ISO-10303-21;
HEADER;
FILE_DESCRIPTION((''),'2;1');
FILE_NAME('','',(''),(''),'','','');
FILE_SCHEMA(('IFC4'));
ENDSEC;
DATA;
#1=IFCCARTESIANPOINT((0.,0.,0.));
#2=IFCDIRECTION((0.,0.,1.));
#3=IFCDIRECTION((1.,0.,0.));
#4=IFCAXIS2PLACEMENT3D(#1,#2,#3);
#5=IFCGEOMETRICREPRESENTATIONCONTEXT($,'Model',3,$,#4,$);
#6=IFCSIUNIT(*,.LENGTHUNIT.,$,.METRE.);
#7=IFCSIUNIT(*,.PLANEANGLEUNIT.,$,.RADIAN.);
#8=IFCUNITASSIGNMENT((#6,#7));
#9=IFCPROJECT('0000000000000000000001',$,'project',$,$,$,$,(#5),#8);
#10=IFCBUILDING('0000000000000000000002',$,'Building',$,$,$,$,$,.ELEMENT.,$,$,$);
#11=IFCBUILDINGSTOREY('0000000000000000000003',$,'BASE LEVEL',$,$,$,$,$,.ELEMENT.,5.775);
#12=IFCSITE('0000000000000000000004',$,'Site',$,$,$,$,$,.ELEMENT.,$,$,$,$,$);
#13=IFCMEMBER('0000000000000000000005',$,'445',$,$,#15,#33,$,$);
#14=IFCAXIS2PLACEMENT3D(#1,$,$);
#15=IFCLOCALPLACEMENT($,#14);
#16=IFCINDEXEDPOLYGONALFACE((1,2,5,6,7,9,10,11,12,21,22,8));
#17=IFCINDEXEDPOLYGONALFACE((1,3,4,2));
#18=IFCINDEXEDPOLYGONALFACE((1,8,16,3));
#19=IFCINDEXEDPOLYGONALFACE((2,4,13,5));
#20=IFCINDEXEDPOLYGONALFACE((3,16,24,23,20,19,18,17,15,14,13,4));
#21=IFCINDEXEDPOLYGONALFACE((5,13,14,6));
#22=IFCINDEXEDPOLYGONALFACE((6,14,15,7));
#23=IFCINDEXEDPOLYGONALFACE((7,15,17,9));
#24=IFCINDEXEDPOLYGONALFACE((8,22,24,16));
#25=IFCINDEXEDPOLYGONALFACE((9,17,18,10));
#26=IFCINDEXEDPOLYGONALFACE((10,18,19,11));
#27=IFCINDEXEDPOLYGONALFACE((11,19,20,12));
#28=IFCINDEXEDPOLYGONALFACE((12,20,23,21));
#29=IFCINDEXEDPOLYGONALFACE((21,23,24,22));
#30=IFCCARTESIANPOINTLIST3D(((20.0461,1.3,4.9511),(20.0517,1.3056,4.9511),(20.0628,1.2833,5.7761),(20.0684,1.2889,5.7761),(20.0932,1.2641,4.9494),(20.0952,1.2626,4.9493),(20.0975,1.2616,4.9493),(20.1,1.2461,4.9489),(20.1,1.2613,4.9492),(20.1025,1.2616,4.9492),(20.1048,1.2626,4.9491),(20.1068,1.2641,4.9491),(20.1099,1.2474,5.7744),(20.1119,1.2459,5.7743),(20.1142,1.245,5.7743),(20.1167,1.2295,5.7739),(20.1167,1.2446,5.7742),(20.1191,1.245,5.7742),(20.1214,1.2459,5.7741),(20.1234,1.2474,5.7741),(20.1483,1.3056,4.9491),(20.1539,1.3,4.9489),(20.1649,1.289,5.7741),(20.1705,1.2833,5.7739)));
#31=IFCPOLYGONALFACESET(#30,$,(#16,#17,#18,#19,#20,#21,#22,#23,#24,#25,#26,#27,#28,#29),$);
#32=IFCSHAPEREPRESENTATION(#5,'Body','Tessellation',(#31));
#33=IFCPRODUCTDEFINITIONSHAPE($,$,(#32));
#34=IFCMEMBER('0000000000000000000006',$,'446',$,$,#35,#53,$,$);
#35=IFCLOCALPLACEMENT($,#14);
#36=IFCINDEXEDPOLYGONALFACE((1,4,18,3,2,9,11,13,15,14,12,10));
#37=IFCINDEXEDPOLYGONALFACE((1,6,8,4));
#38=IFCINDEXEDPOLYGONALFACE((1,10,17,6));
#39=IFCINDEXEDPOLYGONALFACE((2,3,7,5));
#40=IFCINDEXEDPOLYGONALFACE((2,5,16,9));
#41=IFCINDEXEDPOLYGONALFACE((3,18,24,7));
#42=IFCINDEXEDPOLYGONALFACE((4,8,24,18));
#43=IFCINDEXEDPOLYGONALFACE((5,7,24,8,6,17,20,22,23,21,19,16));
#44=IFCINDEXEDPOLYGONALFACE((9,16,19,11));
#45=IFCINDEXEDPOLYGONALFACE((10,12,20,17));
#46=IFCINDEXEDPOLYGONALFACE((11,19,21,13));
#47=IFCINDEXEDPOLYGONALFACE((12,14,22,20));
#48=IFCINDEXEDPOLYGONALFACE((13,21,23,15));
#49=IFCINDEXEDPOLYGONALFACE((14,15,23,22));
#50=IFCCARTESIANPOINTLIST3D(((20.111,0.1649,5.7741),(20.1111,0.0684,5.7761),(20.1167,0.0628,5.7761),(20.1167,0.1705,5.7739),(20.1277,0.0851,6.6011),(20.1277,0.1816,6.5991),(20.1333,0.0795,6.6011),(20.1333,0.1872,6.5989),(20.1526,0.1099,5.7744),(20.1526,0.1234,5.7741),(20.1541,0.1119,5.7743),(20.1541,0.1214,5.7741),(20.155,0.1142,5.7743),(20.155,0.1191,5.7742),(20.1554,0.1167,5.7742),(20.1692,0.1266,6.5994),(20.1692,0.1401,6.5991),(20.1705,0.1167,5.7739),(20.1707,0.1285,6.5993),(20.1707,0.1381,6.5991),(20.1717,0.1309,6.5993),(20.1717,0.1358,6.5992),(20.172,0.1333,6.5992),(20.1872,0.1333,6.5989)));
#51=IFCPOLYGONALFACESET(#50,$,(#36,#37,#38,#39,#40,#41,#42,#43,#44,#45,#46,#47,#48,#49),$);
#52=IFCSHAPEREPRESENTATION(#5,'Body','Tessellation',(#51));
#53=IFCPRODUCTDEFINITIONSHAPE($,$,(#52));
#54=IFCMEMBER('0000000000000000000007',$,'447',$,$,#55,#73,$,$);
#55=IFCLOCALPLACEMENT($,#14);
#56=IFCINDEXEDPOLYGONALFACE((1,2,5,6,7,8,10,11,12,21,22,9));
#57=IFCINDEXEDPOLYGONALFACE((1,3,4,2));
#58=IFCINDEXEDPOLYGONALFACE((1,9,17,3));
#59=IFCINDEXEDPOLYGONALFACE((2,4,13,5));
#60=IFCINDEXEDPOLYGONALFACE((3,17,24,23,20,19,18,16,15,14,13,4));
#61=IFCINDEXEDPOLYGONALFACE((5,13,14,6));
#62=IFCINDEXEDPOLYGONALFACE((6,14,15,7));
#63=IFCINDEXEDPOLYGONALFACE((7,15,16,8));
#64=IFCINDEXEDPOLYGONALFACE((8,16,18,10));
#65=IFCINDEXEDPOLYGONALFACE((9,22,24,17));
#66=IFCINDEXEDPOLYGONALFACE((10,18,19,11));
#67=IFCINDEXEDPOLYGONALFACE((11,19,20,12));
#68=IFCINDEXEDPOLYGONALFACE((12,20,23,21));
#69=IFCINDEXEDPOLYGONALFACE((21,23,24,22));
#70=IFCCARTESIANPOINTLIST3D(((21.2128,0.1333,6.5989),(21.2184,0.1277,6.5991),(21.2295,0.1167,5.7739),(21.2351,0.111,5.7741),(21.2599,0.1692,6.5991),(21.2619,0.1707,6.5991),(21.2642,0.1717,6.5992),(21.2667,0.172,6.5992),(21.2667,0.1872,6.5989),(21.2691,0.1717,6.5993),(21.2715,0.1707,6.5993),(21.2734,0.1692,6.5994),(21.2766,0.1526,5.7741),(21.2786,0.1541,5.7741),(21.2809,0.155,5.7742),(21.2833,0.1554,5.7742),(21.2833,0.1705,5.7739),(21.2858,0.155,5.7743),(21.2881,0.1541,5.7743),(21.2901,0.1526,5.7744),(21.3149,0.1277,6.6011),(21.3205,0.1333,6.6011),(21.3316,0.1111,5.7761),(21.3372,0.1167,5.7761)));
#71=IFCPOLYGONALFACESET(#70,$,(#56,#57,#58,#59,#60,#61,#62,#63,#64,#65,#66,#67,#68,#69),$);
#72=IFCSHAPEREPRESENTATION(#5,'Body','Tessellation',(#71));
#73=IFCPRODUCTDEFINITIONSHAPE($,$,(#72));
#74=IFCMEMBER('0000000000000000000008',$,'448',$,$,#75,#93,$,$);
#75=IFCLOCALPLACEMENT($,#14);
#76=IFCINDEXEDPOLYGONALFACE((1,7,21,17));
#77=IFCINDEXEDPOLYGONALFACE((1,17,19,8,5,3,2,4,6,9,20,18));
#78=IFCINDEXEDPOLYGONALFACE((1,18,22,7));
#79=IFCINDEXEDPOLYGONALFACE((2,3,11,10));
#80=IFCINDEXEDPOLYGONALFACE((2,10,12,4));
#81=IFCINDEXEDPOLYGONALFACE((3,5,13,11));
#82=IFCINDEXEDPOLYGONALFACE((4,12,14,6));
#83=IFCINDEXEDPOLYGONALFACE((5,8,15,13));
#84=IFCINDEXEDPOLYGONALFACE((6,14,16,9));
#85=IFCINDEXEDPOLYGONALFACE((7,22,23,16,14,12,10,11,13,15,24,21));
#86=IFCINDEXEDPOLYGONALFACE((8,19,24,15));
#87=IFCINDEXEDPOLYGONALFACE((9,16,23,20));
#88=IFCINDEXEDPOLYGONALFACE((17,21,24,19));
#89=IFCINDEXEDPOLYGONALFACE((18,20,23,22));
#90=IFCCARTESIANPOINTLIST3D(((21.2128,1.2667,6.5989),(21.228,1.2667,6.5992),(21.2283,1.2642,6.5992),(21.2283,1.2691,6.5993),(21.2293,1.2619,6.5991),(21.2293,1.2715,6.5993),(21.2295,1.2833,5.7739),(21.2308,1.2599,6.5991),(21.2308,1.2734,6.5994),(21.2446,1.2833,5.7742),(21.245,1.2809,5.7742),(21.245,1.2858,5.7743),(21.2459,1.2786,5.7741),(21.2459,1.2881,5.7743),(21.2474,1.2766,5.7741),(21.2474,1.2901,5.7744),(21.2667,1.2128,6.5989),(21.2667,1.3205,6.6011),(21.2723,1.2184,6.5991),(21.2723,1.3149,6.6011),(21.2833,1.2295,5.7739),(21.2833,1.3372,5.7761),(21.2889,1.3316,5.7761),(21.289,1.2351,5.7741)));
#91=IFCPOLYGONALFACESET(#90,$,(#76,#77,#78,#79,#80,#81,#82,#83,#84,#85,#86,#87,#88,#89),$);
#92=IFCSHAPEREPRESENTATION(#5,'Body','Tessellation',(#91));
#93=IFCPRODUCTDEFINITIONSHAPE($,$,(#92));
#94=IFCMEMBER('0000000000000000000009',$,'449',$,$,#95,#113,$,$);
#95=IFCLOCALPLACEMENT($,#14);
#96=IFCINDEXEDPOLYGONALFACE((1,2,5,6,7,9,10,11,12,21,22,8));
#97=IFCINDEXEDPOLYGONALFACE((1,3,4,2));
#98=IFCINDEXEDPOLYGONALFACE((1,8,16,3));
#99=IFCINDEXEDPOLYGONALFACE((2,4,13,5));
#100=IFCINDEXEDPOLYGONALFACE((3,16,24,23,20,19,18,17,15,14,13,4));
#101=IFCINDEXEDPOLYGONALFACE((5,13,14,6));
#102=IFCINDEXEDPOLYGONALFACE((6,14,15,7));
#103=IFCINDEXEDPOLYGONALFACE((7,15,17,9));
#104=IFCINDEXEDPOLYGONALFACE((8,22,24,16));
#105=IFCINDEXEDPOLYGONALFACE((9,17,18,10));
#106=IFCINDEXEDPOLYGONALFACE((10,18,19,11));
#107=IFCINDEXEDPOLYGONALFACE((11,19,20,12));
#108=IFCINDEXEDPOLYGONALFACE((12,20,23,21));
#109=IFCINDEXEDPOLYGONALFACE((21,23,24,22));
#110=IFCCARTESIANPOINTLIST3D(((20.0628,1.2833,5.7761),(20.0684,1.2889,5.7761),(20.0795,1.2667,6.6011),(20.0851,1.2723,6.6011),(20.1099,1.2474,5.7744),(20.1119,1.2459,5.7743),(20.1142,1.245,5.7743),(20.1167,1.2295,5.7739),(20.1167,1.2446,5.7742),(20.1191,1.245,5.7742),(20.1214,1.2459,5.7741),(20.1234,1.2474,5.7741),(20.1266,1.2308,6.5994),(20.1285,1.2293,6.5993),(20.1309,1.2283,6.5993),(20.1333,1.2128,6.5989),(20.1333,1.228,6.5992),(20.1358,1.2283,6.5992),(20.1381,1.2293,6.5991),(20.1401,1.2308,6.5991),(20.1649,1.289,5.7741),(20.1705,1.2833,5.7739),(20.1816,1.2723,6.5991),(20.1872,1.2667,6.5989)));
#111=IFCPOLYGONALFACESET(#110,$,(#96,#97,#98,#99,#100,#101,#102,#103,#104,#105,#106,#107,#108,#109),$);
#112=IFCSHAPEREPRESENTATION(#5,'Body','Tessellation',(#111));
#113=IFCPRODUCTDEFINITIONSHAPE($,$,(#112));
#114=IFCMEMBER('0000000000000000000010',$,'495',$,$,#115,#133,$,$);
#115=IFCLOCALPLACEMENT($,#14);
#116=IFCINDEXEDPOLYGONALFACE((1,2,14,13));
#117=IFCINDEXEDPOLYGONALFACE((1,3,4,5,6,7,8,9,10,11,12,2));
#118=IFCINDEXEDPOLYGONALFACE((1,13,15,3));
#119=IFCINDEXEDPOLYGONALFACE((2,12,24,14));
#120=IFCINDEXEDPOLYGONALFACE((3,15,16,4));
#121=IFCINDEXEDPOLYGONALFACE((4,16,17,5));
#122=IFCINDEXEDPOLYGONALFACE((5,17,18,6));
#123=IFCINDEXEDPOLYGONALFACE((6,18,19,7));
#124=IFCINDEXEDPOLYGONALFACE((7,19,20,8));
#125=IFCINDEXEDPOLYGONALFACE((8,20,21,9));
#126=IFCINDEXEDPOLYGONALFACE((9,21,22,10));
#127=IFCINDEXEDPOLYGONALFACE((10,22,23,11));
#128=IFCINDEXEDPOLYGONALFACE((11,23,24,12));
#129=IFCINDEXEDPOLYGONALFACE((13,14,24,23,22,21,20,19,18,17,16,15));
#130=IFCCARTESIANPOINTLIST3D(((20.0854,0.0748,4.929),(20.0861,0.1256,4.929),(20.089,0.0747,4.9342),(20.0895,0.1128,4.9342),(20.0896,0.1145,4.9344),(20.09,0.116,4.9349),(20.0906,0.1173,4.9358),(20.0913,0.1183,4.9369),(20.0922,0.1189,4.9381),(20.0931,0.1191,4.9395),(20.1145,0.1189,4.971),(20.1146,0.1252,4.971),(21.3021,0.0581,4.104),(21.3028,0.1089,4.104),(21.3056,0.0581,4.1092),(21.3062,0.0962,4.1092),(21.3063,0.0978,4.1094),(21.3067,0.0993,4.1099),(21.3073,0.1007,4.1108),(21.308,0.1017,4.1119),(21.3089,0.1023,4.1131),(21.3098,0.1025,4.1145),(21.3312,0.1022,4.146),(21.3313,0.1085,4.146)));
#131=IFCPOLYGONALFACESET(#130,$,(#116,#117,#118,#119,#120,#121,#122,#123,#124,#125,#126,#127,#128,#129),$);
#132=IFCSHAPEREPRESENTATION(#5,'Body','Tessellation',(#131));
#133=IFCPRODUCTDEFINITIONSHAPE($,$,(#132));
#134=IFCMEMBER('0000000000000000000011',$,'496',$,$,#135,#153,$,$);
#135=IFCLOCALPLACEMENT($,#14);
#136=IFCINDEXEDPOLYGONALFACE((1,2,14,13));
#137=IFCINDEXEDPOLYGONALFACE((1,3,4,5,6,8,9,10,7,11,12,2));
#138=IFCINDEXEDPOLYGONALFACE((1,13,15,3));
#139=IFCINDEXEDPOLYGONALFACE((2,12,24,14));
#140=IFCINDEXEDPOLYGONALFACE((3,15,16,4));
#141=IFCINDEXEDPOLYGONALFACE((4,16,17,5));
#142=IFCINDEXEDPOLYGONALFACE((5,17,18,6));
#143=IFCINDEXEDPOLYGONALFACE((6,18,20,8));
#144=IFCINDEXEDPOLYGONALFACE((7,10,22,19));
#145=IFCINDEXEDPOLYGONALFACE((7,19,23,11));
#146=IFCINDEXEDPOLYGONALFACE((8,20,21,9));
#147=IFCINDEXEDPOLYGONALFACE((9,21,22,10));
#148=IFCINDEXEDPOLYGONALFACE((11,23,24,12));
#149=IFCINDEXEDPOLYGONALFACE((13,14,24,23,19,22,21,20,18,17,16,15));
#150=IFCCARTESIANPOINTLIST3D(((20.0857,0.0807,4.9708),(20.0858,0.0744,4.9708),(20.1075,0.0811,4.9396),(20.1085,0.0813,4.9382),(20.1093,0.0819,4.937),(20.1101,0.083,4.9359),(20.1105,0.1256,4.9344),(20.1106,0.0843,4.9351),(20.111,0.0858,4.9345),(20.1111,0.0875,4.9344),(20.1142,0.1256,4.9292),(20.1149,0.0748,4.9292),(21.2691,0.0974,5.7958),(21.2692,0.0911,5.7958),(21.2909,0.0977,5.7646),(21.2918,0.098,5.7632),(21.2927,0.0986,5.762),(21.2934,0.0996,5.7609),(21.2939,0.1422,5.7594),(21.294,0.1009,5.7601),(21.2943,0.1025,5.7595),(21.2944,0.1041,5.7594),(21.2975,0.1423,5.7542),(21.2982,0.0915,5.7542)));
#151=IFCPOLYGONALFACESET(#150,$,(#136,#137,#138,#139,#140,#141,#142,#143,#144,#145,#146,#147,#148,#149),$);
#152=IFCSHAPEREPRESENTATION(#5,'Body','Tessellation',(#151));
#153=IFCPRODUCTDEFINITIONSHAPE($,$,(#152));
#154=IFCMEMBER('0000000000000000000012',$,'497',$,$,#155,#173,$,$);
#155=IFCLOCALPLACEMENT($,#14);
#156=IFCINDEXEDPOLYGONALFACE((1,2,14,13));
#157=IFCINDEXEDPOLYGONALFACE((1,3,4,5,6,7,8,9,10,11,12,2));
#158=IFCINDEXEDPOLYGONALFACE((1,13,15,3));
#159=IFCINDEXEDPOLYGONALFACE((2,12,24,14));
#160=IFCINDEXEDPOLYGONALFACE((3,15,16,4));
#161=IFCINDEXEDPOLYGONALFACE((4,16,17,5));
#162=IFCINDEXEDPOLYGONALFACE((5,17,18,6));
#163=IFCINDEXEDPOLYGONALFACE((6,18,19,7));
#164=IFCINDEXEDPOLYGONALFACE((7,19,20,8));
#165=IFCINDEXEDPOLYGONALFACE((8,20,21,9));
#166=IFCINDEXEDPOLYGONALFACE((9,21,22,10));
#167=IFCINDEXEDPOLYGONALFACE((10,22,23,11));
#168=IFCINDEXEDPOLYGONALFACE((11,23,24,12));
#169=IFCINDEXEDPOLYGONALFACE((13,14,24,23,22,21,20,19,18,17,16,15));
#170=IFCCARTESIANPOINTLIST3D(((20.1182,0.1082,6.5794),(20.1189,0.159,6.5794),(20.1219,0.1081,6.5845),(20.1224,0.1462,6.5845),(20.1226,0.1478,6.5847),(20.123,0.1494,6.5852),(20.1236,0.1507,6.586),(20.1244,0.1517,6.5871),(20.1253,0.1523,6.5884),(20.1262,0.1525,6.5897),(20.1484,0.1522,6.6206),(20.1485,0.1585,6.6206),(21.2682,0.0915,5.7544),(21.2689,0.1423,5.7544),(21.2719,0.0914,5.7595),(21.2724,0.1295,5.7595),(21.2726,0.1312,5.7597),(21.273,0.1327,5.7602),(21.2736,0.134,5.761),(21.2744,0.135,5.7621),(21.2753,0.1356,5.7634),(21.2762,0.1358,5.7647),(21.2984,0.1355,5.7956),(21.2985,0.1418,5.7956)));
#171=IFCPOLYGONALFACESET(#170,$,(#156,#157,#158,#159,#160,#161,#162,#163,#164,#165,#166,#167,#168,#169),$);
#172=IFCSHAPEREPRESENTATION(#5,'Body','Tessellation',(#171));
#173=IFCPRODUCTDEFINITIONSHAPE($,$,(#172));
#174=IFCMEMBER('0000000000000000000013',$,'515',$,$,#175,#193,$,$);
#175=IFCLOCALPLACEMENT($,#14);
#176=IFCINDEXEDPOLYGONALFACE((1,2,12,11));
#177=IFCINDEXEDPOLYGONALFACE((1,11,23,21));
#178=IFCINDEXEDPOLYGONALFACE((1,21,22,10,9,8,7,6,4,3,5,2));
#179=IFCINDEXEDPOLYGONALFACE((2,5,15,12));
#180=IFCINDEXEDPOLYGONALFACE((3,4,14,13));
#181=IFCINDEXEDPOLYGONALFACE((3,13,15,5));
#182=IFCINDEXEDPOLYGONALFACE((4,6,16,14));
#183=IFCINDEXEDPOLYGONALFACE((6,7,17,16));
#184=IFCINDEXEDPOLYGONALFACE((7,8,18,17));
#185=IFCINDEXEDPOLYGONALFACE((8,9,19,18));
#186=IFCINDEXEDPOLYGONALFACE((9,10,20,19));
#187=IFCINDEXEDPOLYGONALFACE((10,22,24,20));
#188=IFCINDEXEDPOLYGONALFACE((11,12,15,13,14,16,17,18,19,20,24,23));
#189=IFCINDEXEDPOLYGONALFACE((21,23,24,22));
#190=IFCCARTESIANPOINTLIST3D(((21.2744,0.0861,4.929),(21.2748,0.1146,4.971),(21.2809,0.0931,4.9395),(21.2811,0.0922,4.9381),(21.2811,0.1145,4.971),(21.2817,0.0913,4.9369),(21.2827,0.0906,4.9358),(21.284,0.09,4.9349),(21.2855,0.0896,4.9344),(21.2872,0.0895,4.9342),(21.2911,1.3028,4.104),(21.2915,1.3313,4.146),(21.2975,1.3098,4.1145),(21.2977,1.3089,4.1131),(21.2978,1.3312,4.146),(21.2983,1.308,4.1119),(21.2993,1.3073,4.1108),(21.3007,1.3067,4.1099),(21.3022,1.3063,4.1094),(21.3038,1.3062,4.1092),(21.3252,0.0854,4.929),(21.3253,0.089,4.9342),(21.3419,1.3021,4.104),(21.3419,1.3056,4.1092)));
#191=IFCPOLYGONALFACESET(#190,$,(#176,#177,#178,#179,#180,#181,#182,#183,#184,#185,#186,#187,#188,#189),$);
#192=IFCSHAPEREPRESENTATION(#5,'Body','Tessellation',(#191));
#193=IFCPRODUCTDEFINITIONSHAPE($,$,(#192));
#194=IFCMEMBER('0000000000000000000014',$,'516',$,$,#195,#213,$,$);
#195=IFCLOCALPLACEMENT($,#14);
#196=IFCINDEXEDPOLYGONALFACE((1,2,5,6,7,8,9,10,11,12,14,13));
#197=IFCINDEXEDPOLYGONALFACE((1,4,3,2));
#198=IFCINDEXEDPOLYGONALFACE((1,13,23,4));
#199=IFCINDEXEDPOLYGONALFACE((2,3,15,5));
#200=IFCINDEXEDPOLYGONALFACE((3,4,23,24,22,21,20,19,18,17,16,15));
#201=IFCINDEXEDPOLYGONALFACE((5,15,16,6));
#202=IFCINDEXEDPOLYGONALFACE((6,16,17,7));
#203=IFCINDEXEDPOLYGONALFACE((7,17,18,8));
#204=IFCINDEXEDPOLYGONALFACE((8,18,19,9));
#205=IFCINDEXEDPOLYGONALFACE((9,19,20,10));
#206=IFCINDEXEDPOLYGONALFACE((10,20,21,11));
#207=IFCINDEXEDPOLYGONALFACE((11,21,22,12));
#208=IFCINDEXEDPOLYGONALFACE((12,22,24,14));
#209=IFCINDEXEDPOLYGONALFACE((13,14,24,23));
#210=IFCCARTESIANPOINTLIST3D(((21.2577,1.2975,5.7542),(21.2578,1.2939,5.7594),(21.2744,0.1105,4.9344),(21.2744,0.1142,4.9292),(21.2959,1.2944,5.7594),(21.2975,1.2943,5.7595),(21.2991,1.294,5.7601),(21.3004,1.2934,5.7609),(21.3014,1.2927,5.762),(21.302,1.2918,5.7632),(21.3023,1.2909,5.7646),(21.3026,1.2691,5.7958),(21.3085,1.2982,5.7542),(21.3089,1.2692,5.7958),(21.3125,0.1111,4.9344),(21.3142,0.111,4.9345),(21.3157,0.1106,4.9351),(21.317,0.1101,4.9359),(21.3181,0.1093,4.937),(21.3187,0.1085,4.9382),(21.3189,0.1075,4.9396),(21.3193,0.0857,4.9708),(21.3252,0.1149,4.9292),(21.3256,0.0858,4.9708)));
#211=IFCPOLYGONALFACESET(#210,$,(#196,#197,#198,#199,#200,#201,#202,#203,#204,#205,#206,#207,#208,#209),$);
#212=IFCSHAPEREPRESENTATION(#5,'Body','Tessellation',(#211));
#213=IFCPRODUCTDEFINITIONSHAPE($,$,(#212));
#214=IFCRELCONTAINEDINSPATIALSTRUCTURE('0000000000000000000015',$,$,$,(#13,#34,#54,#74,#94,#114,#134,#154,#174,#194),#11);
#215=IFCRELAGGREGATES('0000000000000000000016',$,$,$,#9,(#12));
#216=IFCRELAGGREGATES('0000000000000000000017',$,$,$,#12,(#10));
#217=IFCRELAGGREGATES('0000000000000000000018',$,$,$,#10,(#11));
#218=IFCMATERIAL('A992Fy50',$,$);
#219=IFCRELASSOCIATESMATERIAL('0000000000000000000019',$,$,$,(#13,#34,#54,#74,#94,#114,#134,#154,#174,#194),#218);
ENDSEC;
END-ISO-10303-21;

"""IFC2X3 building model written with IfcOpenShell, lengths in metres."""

from ifc_helpers import new_model, si_unit, frame, origin_with_axes, origin_2d_with_axis, place, context, project, spatial, l_section, extrude, material, element, save


model = new_model("IFC2X3")

# Units and contexts
model_context = context("Model", 3, world=origin_with_axes())
ifc_project = project(units=[si_unit("LENGTHUNIT", "METRE"), si_unit("PLANEANGLEUNIT", "RADIAN")], contexts=[model_context])

# Site, building, storey
site = spatial("IfcSite", under=ifc_project, Name="Site", CompositionType="ELEMENT")
building = spatial("IfcBuilding", under=site, Name="Building", CompositionType="ELEMENT")
storey = spatial("IfcBuildingStorey", under=building, Name="BASE LEVEL", CompositionType="ELEMENT", Elevation=5.775)

# Shared definitions
ifc_material = material(Name="A992Fy50")

# Members
for number, where, z_axis, x_axis, name in (
    (1, (20.1, 1.3, 4.95), (0.020194, -0.020194, 0.999592), (0.707107, 0.707107, 0.0), "445"),
    (2, (20.1167, 0.1167, 5.775), (0.020194, 0.020194, 0.999592), (-0.707107, 0.707107, 0.0), "446"),
    (3, (21.2833, 0.1167, 5.775), (-0.020194, 0.020194, 0.999592), (-0.707107, -0.707107, 0.0), "447"),
    (4, (21.2833, 1.2833, 5.775), (-0.020194, -0.020194, 0.999592), (0.707107, -0.707107, 0.0), "448"),
    (5, (20.1167, 1.2833, 5.775), (0.020194, -0.020194, 0.999592), (0.707107, 0.707107, 0.0), "449"),
):
    element("IfcMember", number, at=place(None, frame(where, z_axis=z_axis, x_axis=x_axis)), inside=storey, material=ifc_material, Name=name, context=model_context, shape_type="SweptSolid", body=[
        extrude(l_section(Depth=0.0762, Width=0.0762, Thickness=0.0079, FilletRadius=0.0096, at=origin_2d_with_axis()), origin_with_axes(), (0.0, 0.0, 1.0), 0.8253),
    ])
member_1_placement = place(None, frame((21.3167, 0.0833, 4.125), z_axis=(-0.827611, 0.011337, 0.561188), x_axis=(-0.013697, -0.999906, 0.0)))
element("IfcMember", 6, at=member_1_placement, inside=storey, material=ifc_material, Name="495", context=model_context, shape_type="SweptSolid", body=[
    extrude(l_section(Depth=0.0508, Width=0.0508, Thickness=0.0063, FilletRadius=0.0063, at=origin_2d_with_axis()), origin_with_axes(), (0.0, 0.0, 1.0), 1.4701),
])
member_2_placement = place(None, frame((20.1, 0.1, 4.95), z_axis=(0.820261, 0.011553, 0.571872), x_axis=(-0.014083, 0.999901, 0.0)))
element("IfcMember", 7, at=member_2_placement, inside=storey, material=ifc_material, Name="496", context=model_context, shape_type="SweptSolid", body=[
    extrude(l_section(Depth=0.0508, Width=0.0508, Thickness=0.0063, FilletRadius=0.0063, at=origin_2d_with_axis()), origin_with_axes(), (0.0, 0.0, 1.0), 1.4426),
])
member_3_placement = place(None, frame((21.2833, 0.1167, 5.775), z_axis=(-0.812482, 0.011775, 0.582867), x_axis=(-0.015383, -0.999882, 0.0)))
element("IfcMember", 8, at=member_3_placement, inside=storey, material=ifc_material, Name="497", context=model_context, shape_type="SweptSolid", body=[
    extrude(l_section(Depth=0.0508, Width=0.0508, Thickness=0.0063, FilletRadius=0.0063, at=origin_2d_with_axis()), origin_with_axes(), (0.0, 0.0, 1.0), 1.4154),
])
member_4_placement = place(None, frame((21.3167, 1.3167, 4.125), z_axis=(-0.011337, -0.827611, 0.561188), x_axis=(0.999906, -0.013697, 0.0)))
element("IfcMember", 9, at=member_4_placement, inside=storey, material=ifc_material, Name="515", context=model_context, shape_type="SweptSolid", body=[
    extrude(l_section(Depth=0.0508, Width=0.0508, Thickness=0.0063, FilletRadius=0.0063, at=origin_2d_with_axis()), origin_with_axes(), (0.0, 0.0, 1.0), 1.4701),
])
member_5_placement = place(None, frame((21.3, 0.1, 4.95), z_axis=(-0.011553, 0.820261, 0.571872), x_axis=(-0.999889, -0.014924, 0.0)))
element("IfcMember", 10, at=member_5_placement, inside=storey, material=ifc_material, Name="516", context=model_context, shape_type="SweptSolid", body=[
    extrude(l_section(Depth=0.0508, Width=0.0508, Thickness=0.0063, FilletRadius=0.0063, at=origin_2d_with_axis()), origin_with_axes(), (0.0, 0.0, 1.0), 1.4426),
])

save(model, "model.ifc")
